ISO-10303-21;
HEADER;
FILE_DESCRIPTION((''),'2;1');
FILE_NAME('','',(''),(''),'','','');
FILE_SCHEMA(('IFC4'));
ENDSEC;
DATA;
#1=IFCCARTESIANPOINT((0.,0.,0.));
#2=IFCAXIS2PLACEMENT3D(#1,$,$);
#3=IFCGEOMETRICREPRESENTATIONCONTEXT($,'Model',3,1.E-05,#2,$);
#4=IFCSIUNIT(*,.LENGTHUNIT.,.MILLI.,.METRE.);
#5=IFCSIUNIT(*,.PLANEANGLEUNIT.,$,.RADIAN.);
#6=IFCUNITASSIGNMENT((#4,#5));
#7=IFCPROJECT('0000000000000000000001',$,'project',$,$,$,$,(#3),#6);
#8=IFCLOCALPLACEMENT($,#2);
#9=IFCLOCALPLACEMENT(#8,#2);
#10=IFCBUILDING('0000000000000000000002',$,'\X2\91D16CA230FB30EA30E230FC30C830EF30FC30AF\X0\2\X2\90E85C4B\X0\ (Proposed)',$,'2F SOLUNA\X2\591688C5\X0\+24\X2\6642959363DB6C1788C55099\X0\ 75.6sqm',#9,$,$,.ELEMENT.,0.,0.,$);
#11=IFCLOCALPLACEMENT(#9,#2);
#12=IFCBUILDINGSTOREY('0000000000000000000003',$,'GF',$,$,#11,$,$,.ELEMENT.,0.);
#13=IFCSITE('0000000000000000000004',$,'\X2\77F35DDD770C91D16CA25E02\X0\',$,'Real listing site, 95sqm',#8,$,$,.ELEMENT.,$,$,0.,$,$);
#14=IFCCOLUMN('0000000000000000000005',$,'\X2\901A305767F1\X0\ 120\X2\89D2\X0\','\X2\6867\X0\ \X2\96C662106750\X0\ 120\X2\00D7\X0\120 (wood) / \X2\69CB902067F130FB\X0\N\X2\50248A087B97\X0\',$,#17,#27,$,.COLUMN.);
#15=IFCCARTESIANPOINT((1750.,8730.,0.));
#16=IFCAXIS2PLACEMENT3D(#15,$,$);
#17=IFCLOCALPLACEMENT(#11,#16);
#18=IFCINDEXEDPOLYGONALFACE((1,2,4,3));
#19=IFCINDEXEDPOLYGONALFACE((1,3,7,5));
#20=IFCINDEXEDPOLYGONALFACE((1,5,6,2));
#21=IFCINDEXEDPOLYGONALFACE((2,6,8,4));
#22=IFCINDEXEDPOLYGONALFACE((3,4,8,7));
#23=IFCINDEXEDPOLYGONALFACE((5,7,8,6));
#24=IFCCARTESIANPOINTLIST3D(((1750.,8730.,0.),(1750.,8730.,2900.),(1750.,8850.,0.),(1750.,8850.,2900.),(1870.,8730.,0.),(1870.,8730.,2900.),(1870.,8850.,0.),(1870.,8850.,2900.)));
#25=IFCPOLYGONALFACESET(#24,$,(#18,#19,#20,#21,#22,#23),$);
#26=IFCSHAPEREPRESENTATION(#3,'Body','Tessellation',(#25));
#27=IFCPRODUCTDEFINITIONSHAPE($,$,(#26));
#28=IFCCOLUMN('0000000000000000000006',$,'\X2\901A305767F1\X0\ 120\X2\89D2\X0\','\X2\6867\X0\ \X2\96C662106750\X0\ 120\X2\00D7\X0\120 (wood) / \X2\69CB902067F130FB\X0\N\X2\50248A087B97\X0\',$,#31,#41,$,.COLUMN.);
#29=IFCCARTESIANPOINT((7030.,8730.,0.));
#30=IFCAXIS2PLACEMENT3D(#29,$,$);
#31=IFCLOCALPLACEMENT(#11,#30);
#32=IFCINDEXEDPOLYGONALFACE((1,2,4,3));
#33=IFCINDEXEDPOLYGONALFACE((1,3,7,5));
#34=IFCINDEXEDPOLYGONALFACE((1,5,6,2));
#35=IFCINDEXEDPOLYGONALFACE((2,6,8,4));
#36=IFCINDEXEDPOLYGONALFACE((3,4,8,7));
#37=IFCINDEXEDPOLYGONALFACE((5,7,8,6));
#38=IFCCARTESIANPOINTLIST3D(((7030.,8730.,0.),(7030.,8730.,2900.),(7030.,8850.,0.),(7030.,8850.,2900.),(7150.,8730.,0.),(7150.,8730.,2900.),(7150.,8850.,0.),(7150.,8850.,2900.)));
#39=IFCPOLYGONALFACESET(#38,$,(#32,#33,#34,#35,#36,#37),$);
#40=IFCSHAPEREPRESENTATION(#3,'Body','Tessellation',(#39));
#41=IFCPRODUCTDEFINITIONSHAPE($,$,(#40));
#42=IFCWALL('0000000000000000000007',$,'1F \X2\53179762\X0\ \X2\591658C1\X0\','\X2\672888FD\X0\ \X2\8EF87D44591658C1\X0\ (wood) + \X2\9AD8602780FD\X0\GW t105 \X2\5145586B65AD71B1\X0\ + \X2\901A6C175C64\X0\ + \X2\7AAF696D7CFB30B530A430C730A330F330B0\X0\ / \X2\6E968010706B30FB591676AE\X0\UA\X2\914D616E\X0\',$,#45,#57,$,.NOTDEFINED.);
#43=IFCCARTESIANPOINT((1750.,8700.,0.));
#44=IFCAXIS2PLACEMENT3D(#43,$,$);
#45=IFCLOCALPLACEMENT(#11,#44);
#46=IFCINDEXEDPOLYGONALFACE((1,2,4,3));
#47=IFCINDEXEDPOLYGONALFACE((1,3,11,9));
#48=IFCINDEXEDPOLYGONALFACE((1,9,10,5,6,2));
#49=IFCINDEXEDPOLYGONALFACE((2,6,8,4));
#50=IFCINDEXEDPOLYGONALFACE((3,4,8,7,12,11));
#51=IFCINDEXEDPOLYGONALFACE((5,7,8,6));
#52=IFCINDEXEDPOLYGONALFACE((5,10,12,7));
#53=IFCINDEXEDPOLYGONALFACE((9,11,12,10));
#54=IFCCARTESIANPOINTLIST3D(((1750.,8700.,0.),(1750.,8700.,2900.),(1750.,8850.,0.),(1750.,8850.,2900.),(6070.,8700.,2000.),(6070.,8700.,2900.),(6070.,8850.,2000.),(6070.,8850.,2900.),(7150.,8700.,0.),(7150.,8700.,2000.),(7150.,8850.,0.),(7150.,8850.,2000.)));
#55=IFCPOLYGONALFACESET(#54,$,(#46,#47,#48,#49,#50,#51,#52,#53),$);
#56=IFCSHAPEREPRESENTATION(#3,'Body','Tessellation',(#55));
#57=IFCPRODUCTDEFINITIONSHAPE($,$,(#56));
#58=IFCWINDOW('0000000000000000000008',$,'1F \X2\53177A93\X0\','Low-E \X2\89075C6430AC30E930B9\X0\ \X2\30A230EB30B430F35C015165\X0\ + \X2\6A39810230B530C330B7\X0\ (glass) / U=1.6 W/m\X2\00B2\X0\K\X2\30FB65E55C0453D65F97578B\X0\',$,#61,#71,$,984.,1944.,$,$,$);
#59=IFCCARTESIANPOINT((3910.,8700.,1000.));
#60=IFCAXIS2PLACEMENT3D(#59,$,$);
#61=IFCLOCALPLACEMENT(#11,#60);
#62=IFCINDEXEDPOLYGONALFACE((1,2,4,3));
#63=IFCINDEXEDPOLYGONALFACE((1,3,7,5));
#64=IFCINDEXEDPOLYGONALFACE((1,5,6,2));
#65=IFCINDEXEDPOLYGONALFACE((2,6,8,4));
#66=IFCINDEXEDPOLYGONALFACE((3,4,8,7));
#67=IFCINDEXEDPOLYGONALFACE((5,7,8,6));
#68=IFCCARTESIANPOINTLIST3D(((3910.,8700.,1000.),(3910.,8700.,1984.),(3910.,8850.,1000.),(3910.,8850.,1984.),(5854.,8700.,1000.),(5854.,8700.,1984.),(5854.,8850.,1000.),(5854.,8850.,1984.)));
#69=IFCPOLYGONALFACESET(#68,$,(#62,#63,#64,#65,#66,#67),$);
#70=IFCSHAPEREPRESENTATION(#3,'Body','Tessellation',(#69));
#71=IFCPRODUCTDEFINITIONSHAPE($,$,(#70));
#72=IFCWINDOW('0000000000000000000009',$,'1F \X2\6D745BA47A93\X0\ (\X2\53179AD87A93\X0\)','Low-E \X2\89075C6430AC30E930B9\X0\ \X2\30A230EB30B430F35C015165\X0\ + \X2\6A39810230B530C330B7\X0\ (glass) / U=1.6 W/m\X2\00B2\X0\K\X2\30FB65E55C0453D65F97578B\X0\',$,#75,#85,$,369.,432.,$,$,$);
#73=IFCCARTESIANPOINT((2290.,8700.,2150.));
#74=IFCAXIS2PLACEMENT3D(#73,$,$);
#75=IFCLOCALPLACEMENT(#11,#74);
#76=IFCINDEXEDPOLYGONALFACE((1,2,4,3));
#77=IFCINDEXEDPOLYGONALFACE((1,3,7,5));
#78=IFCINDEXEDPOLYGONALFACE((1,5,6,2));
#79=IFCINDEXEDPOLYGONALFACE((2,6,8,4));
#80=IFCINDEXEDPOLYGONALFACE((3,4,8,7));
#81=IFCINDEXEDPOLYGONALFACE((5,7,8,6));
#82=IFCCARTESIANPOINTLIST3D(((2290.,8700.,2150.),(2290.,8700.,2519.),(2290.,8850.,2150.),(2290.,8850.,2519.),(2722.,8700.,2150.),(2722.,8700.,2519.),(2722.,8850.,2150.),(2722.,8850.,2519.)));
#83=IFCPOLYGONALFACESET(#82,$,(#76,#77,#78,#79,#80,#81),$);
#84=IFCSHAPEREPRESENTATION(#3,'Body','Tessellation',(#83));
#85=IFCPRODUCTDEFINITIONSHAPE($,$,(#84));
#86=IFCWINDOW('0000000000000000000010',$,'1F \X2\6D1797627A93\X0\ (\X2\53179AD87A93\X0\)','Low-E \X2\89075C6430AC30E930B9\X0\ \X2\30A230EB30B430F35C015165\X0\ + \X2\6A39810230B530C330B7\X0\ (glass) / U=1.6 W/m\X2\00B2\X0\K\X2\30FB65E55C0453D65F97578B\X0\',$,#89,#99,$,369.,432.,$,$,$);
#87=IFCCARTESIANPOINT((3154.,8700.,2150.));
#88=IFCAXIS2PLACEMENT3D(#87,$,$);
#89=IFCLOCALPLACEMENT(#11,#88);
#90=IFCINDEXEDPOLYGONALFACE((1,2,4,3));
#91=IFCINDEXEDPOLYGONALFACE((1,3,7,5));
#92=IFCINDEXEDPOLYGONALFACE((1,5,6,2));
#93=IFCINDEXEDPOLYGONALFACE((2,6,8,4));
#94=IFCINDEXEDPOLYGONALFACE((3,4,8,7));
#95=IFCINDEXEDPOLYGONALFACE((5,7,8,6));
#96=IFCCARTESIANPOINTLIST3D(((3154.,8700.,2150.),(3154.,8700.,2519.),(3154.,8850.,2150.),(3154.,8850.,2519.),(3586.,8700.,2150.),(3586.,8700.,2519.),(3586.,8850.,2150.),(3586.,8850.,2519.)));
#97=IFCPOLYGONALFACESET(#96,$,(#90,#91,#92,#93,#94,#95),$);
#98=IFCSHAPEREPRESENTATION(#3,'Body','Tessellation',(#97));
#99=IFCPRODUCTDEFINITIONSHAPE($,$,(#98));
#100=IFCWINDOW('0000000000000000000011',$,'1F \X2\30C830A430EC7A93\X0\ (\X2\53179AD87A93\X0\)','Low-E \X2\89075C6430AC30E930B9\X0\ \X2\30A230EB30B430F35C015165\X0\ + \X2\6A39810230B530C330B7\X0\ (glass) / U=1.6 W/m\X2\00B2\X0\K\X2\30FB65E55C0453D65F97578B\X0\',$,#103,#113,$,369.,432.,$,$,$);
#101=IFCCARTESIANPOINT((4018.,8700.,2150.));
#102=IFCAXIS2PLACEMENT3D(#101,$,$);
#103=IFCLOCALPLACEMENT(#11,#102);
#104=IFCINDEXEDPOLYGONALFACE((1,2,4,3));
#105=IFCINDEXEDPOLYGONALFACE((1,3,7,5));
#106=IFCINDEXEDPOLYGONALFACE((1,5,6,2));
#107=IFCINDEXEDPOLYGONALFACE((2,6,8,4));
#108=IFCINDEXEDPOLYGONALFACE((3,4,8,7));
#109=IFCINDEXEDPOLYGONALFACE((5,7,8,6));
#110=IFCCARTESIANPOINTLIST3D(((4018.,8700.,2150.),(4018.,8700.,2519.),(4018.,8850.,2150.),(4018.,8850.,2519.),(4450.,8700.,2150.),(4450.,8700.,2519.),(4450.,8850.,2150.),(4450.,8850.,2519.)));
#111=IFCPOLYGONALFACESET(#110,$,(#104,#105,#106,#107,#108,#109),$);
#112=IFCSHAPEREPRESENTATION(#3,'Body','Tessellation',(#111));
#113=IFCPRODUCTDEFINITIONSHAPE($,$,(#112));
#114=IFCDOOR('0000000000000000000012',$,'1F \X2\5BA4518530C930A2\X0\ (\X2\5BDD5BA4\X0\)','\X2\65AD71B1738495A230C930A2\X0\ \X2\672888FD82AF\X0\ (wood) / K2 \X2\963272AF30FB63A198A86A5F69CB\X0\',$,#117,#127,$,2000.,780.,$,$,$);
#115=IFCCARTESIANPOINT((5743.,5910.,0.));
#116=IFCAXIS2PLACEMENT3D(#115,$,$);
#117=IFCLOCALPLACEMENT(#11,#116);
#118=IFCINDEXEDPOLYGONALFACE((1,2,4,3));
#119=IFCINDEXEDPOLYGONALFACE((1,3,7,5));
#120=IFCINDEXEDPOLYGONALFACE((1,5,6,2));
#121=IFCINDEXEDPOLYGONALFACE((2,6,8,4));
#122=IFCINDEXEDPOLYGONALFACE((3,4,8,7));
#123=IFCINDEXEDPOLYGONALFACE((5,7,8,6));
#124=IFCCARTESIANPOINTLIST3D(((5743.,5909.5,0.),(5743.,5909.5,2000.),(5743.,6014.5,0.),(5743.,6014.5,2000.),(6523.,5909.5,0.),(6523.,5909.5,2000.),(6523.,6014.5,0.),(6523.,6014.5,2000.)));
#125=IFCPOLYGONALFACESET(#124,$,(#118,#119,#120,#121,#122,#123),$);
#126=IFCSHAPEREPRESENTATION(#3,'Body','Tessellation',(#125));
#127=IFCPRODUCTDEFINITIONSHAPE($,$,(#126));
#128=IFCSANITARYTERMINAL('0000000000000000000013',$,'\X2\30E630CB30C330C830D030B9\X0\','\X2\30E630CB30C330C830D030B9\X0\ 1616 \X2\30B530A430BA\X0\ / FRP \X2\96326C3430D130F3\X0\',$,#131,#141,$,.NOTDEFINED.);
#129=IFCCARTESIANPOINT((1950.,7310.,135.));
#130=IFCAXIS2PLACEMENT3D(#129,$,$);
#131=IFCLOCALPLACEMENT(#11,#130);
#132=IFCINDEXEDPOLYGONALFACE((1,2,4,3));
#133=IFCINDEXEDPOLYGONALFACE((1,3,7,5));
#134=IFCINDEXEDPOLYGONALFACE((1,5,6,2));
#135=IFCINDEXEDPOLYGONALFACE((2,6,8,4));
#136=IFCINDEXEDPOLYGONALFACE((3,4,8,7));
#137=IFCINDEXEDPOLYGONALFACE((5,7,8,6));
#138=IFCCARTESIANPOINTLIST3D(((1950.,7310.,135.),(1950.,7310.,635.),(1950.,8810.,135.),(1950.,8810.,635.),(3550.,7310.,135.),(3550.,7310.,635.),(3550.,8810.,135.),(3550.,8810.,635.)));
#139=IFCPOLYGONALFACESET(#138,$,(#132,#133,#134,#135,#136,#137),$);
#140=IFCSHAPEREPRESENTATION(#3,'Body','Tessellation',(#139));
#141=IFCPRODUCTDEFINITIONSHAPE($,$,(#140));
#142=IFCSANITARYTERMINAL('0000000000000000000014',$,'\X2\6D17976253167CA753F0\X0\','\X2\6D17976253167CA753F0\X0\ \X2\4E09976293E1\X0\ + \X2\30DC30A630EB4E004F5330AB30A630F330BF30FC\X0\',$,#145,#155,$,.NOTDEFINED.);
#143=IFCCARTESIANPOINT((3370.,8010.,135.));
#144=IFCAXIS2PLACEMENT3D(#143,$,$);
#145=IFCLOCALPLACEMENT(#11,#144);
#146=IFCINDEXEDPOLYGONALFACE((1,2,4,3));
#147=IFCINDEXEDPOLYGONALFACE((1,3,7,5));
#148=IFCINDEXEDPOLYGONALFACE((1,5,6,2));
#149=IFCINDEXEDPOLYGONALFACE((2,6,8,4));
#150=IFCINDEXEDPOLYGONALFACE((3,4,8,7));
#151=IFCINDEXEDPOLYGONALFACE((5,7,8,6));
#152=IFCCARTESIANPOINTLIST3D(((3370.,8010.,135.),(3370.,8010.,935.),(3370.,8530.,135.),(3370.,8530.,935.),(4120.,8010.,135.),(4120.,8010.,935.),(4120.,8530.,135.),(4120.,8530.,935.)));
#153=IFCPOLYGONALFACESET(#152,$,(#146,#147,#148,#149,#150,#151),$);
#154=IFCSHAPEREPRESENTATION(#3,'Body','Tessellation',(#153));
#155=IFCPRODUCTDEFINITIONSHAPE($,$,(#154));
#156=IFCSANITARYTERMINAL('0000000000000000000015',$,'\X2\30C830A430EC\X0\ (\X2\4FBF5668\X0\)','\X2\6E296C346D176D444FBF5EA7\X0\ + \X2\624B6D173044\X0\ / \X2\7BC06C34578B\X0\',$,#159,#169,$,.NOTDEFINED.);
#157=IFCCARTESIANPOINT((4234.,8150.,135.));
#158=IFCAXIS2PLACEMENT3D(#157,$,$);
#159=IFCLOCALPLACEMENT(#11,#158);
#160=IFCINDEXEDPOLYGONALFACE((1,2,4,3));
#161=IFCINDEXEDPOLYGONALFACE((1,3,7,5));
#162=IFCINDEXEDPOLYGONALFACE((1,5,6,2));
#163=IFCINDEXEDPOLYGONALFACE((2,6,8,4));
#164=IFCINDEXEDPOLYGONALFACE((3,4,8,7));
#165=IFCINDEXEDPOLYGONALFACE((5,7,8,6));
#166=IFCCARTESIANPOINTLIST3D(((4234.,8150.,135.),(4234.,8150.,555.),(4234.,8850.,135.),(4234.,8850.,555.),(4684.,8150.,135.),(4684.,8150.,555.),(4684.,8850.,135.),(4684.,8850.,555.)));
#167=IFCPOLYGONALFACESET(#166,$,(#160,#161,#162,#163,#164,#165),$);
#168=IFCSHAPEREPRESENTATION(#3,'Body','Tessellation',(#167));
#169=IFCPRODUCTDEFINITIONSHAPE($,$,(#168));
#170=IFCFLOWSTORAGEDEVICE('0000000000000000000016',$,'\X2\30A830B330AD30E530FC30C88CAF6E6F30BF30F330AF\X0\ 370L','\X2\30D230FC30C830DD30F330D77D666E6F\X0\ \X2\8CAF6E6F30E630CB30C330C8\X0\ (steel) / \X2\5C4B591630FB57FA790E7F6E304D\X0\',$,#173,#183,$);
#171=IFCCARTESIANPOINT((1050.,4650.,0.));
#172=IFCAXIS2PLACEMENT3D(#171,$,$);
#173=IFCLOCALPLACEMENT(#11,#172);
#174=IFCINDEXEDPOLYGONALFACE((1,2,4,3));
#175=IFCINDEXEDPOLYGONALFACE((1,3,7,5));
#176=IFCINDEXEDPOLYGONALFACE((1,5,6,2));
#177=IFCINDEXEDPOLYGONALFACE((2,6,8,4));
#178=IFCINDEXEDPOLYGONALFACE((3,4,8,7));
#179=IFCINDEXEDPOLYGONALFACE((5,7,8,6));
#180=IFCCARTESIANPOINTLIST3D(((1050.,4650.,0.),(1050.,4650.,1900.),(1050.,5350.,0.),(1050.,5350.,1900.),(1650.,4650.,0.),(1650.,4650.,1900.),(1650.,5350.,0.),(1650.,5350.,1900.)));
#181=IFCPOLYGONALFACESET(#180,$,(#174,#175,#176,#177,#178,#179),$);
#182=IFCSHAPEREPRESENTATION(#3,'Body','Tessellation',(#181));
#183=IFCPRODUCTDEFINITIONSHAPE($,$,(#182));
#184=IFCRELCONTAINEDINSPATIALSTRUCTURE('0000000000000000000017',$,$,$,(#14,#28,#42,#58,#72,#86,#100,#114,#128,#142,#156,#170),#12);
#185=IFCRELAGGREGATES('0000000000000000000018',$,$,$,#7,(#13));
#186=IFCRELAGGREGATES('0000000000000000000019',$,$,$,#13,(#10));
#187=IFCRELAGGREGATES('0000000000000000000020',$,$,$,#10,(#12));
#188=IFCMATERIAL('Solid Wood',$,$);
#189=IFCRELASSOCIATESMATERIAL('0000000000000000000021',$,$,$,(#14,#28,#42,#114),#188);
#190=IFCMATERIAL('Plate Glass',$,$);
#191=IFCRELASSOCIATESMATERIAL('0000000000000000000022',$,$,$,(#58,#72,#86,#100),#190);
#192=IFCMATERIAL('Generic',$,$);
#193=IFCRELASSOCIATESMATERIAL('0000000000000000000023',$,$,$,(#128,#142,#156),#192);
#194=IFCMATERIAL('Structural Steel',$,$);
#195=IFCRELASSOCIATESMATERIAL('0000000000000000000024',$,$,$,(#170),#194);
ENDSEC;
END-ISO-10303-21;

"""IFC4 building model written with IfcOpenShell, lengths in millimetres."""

from ifc_helpers import new_model, si_unit, frame, frame_2d, origin, place, context, project, spatial, rectangle, extrude, material, element, fill, save


model = new_model("IFC4")

# Units and contexts
model_context = context("Model", 3, precision=1e-05, world=origin())
ifc_project = project(units=[si_unit("LENGTHUNIT", "METRE", prefix="MILLI"), si_unit("PLANEANGLEUNIT", "RADIAN")], contexts=[model_context])

# Site, building, storey
site_placement = place(None, origin())
site = spatial("IfcSite", under=ifc_project, at=site_placement, Name="石川県金沢市", ObjectType="Real listing site, 95sqm", CompositionType="ELEMENT", RefElevation=0.0)
building_placement = place(site_placement, origin())
building = spatial("IfcBuilding", under=site, at=building_placement, Name="金沢・リモートワーク2部屋 (Proposed)", ObjectType="2F SOLUNA外装+24時間換気装備 75.6sqm", CompositionType="ELEMENT", ElevationOfRefHeight=0.0, ElevationOfTerrain=0.0)
storey_placement = place(building_placement, origin())
storey = spatial("IfcBuildingStorey", under=building, at=storey_placement, Name="GF", CompositionType="ELEMENT", Elevation=0.0)

# Columns
ifc_material_1 = material(Name="Solid Wood")
column_1_placement = place(storey_placement, frame((1750.0, 8730.0, 0.0)))
element("IfcColumn", 1, at=column_1_placement, inside=storey, material=ifc_material_1, Name="通し柱 120角", Description="桧 集成材 120×120 (wood) / 構造柱・N値計算", PredefinedType="COLUMN", context=model_context, shape_type="SweptSolid", body=[
    extrude(rectangle(XDim=120.0, YDim=120.0, at=frame_2d((60.0, 60.0))), frame((1750.0, 8730.0, 0.0)), (0.0, 0.0, 1.0), 2900.0),
])
column_2_placement = place(storey_placement, frame((7030.0, 8730.0, 0.0)))
element("IfcColumn", 2, at=column_2_placement, inside=storey, material=ifc_material_1, Name="通し柱 120角", Description="桧 集成材 120×120 (wood) / 構造柱・N値計算", PredefinedType="COLUMN", context=model_context, shape_type="SweptSolid", body=[
    extrude(rectangle(XDim=120.0, YDim=120.0, at=frame_2d((60.0, 60.0))), frame((7030.0, 8730.0, 0.0)), (0.0, 0.0, 1.0), 2900.0),
])

# Wall, openings, windows
wall_1_placement = place(storey_placement, frame((1750.0, 8700.0, 0.0)))
wall_1 = element("IfcWall", 3, at=wall_1_placement, inside=storey, material=ifc_material_1, Name="1F 北面 外壁", Description="木製 軸組外壁 (wood) + 高性能GW t105 充填断熱 + 通気層 + 窯業系サイディング / 準耐火・外皮UA配慮", PredefinedType="NOTDEFINED", context=model_context, shape_type="SweptSolid", body=[
    extrude(rectangle(XDim=5400.0, YDim=150.0, at=frame_2d((2700.0, 75.0))), frame((1750.0, 8700.0, 0.0)), (0.0, 0.0, 1.0), 2900.0),
])
opening_1_placement = place(storey_placement, frame((3910.0, 8700.0, 1000.0)))
opening_1 = element("IfcOpeningElement", 4, at=opening_1_placement, cuts=wall_1, PredefinedType="NOTDEFINED", context=model_context, shape_type="SweptSolid", body=[
    extrude(rectangle(XDim=1944.0, YDim=150.0, at=frame_2d((972.0, 75.0))), frame((3910.0, 8700.0, 1000.0)), (0.0, 0.0, 1.0), 984.0),
])
opening_2_placement = place(storey_placement, frame((2290.0, 8700.0, 2150.0)))
opening_2 = element("IfcOpeningElement", 5, at=opening_2_placement, cuts=wall_1, PredefinedType="NOTDEFINED", context=model_context, shape_type="SweptSolid", body=[
    extrude(rectangle(XDim=432.0, YDim=150.0, at=frame_2d((216.0, 75.0))), frame((2290.0, 8700.0, 2150.0)), (0.0, 0.0, 1.0), 369.0),
])
opening_3_placement = place(storey_placement, frame((3154.0, 8700.0, 2150.0)))
opening_3 = element("IfcOpeningElement", 6, at=opening_3_placement, cuts=wall_1, PredefinedType="NOTDEFINED", context=model_context, shape_type="SweptSolid", body=[
    extrude(rectangle(XDim=432.0, YDim=150.0, at=frame_2d((216.0, 75.0))), frame((3154.0, 8700.0, 2150.0)), (0.0, 0.0, 1.0), 369.0),
])
opening_4_placement = place(storey_placement, frame((4018.0, 8700.0, 2150.0)))
opening_4 = element("IfcOpeningElement", 7, at=opening_4_placement, cuts=wall_1, PredefinedType="NOTDEFINED", context=model_context, shape_type="SweptSolid", body=[
    extrude(rectangle(XDim=432.0, YDim=150.0, at=frame_2d((216.0, 75.0))), frame((4018.0, 8700.0, 2150.0)), (0.0, 0.0, 1.0), 369.0),
])
ifc_material_2 = material(Name="Plate Glass")
window_1_placement = place(storey_placement, frame((3910.0, 8700.0, 1000.0)))
window_1 = element("IfcWindow", 8, at=window_1_placement, inside=storey, material=ifc_material_2, Name="1F 北窓", Description="Low-E 複層ガラス アルゴン封入 + 樹脂サッシ (glass) / U=1.6 W/m²K・日射取得型", OverallHeight=984.0, OverallWidth=1944.0, context=model_context, shape_type="SweptSolid", body=[
    extrude(rectangle(XDim=1944.0, YDim=150.0, at=frame_2d((972.0, 75.0))), frame((3910.0, 8700.0, 1000.0)), (0.0, 0.0, 1.0), 984.0),
])
fill(opening_1, window_1)
window_2_placement = place(storey_placement, frame((2290.0, 8700.0, 2150.0)))
window_2 = element("IfcWindow", 9, at=window_2_placement, inside=storey, material=ifc_material_2, Name="1F 浴室窓 (北高窓)", Description="Low-E 複層ガラス アルゴン封入 + 樹脂サッシ (glass) / U=1.6 W/m²K・日射取得型", OverallHeight=369.0, OverallWidth=432.0, context=model_context, shape_type="SweptSolid", body=[
    extrude(rectangle(XDim=432.0, YDim=150.0, at=frame_2d((216.0, 75.0))), frame((2290.0, 8700.0, 2150.0)), (0.0, 0.0, 1.0), 369.0),
])
fill(opening_2, window_2)
window_3_placement = place(storey_placement, frame((3154.0, 8700.0, 2150.0)))
window_3 = element("IfcWindow", 10, at=window_3_placement, inside=storey, material=ifc_material_2, Name="1F 洗面窓 (北高窓)", Description="Low-E 複層ガラス アルゴン封入 + 樹脂サッシ (glass) / U=1.6 W/m²K・日射取得型", OverallHeight=369.0, OverallWidth=432.0, context=model_context, shape_type="SweptSolid", body=[
    extrude(rectangle(XDim=432.0, YDim=150.0, at=frame_2d((216.0, 75.0))), frame((3154.0, 8700.0, 2150.0)), (0.0, 0.0, 1.0), 369.0),
])
fill(opening_3, window_3)
window_4_placement = place(storey_placement, frame((4018.0, 8700.0, 2150.0)))
window_4 = element("IfcWindow", 11, at=window_4_placement, inside=storey, material=ifc_material_2, Name="1F トイレ窓 (北高窓)", Description="Low-E 複層ガラス アルゴン封入 + 樹脂サッシ (glass) / U=1.6 W/m²K・日射取得型", OverallHeight=369.0, OverallWidth=432.0, context=model_context, shape_type="SweptSolid", body=[
    extrude(rectangle(XDim=432.0, YDim=150.0, at=frame_2d((216.0, 75.0))), frame((4018.0, 8700.0, 2150.0)), (0.0, 0.0, 1.0), 369.0),
])
fill(opening_4, window_4)

# Door
door_1_placement = place(storey_placement, frame((5743.0, 5910.0, 0.0)))
element("IfcDoor", 12, at=door_1_placement, inside=storey, material=ifc_material_1, Name="1F 室内ドア (寝室)", Description="断熱玄関ドア 木製芯 (wood) / K2 防犯・採風機構", OverallHeight=2000.0, OverallWidth=780.0, context=model_context, shape_type="SweptSolid", body=[
    extrude(rectangle(XDim=780.0, YDim=105.0, at=frame_2d((390.0, 52.0))), frame((5743.0, 5910.0, 0.0)), (0.0, 0.0, 1.0), 2000.0),
])

# Sanitary terminals
ifc_material_3 = material(Name="Generic")
sanitary_terminal_1_placement = place(storey_placement, frame((1950.0, 7310.0, 135.0)))
element("IfcSanitaryTerminal", 13, at=sanitary_terminal_1_placement, inside=storey, material=ifc_material_3, Name="ユニットバス", Description="ユニットバス 1616 サイズ / FRP 防水パン", PredefinedType="NOTDEFINED", context=model_context, shape_type="SweptSolid", body=[
    extrude(rectangle(XDim=1600.0, YDim=1500.0, at=frame_2d((800.0, 750.0))), frame((1950.0, 7310.0, 135.0)), (0.0, 0.0, 1.0), 500.0),
])
sanitary_terminal_2_placement = place(storey_placement, frame((3370.0, 8010.0, 135.0)))
element("IfcSanitaryTerminal", 14, at=sanitary_terminal_2_placement, inside=storey, material=ifc_material_3, Name="洗面化粧台", Description="洗面化粧台 三面鏡 + ボウル一体カウンター", PredefinedType="NOTDEFINED", context=model_context, shape_type="SweptSolid", body=[
    extrude(rectangle(XDim=750.0, YDim=520.0, at=frame_2d((375.0, 260.0))), frame((3370.0, 8010.0, 135.0)), (0.0, 0.0, 1.0), 800.0),
])
sanitary_terminal_3_placement = place(storey_placement, frame((4234.0, 8150.0, 135.0)))
element("IfcSanitaryTerminal", 15, at=sanitary_terminal_3_placement, inside=storey, material=ifc_material_3, Name="トイレ (便器)", Description="温水洗浄便座 + 手洗い / 節水型", PredefinedType="NOTDEFINED", context=model_context, shape_type="SweptSolid", body=[
    extrude(rectangle(XDim=450.0, YDim=700.0, at=frame_2d((225.0, 350.0))), frame((4234.0, 8150.0, 135.0)), (0.0, 0.0, 1.0), 420.0),
])

# Flow storage device
ifc_material_4 = material(Name="Structural Steel")
flow_storage_device_placement = place(storey_placement, frame((1050.0, 4650.0, 0.0)))
element("IfcFlowStorageDevice", 16, at=flow_storage_device_placement, inside=storey, material=ifc_material_4, Name="エコキュート貯湯タンク 370L", Description="ヒートポンプ給湯 貯湯ユニット (steel) / 屋外・基礎置き", context=model_context, shape_type="SweptSolid", body=[
    extrude(rectangle(XDim=600.0, YDim=700.0, at=frame_2d((300.0, 350.0))), frame((1050.0, 4650.0, 0.0)), (0.0, 0.0, 1.0), 1900.0),
])

save(model, "model.ifc")
